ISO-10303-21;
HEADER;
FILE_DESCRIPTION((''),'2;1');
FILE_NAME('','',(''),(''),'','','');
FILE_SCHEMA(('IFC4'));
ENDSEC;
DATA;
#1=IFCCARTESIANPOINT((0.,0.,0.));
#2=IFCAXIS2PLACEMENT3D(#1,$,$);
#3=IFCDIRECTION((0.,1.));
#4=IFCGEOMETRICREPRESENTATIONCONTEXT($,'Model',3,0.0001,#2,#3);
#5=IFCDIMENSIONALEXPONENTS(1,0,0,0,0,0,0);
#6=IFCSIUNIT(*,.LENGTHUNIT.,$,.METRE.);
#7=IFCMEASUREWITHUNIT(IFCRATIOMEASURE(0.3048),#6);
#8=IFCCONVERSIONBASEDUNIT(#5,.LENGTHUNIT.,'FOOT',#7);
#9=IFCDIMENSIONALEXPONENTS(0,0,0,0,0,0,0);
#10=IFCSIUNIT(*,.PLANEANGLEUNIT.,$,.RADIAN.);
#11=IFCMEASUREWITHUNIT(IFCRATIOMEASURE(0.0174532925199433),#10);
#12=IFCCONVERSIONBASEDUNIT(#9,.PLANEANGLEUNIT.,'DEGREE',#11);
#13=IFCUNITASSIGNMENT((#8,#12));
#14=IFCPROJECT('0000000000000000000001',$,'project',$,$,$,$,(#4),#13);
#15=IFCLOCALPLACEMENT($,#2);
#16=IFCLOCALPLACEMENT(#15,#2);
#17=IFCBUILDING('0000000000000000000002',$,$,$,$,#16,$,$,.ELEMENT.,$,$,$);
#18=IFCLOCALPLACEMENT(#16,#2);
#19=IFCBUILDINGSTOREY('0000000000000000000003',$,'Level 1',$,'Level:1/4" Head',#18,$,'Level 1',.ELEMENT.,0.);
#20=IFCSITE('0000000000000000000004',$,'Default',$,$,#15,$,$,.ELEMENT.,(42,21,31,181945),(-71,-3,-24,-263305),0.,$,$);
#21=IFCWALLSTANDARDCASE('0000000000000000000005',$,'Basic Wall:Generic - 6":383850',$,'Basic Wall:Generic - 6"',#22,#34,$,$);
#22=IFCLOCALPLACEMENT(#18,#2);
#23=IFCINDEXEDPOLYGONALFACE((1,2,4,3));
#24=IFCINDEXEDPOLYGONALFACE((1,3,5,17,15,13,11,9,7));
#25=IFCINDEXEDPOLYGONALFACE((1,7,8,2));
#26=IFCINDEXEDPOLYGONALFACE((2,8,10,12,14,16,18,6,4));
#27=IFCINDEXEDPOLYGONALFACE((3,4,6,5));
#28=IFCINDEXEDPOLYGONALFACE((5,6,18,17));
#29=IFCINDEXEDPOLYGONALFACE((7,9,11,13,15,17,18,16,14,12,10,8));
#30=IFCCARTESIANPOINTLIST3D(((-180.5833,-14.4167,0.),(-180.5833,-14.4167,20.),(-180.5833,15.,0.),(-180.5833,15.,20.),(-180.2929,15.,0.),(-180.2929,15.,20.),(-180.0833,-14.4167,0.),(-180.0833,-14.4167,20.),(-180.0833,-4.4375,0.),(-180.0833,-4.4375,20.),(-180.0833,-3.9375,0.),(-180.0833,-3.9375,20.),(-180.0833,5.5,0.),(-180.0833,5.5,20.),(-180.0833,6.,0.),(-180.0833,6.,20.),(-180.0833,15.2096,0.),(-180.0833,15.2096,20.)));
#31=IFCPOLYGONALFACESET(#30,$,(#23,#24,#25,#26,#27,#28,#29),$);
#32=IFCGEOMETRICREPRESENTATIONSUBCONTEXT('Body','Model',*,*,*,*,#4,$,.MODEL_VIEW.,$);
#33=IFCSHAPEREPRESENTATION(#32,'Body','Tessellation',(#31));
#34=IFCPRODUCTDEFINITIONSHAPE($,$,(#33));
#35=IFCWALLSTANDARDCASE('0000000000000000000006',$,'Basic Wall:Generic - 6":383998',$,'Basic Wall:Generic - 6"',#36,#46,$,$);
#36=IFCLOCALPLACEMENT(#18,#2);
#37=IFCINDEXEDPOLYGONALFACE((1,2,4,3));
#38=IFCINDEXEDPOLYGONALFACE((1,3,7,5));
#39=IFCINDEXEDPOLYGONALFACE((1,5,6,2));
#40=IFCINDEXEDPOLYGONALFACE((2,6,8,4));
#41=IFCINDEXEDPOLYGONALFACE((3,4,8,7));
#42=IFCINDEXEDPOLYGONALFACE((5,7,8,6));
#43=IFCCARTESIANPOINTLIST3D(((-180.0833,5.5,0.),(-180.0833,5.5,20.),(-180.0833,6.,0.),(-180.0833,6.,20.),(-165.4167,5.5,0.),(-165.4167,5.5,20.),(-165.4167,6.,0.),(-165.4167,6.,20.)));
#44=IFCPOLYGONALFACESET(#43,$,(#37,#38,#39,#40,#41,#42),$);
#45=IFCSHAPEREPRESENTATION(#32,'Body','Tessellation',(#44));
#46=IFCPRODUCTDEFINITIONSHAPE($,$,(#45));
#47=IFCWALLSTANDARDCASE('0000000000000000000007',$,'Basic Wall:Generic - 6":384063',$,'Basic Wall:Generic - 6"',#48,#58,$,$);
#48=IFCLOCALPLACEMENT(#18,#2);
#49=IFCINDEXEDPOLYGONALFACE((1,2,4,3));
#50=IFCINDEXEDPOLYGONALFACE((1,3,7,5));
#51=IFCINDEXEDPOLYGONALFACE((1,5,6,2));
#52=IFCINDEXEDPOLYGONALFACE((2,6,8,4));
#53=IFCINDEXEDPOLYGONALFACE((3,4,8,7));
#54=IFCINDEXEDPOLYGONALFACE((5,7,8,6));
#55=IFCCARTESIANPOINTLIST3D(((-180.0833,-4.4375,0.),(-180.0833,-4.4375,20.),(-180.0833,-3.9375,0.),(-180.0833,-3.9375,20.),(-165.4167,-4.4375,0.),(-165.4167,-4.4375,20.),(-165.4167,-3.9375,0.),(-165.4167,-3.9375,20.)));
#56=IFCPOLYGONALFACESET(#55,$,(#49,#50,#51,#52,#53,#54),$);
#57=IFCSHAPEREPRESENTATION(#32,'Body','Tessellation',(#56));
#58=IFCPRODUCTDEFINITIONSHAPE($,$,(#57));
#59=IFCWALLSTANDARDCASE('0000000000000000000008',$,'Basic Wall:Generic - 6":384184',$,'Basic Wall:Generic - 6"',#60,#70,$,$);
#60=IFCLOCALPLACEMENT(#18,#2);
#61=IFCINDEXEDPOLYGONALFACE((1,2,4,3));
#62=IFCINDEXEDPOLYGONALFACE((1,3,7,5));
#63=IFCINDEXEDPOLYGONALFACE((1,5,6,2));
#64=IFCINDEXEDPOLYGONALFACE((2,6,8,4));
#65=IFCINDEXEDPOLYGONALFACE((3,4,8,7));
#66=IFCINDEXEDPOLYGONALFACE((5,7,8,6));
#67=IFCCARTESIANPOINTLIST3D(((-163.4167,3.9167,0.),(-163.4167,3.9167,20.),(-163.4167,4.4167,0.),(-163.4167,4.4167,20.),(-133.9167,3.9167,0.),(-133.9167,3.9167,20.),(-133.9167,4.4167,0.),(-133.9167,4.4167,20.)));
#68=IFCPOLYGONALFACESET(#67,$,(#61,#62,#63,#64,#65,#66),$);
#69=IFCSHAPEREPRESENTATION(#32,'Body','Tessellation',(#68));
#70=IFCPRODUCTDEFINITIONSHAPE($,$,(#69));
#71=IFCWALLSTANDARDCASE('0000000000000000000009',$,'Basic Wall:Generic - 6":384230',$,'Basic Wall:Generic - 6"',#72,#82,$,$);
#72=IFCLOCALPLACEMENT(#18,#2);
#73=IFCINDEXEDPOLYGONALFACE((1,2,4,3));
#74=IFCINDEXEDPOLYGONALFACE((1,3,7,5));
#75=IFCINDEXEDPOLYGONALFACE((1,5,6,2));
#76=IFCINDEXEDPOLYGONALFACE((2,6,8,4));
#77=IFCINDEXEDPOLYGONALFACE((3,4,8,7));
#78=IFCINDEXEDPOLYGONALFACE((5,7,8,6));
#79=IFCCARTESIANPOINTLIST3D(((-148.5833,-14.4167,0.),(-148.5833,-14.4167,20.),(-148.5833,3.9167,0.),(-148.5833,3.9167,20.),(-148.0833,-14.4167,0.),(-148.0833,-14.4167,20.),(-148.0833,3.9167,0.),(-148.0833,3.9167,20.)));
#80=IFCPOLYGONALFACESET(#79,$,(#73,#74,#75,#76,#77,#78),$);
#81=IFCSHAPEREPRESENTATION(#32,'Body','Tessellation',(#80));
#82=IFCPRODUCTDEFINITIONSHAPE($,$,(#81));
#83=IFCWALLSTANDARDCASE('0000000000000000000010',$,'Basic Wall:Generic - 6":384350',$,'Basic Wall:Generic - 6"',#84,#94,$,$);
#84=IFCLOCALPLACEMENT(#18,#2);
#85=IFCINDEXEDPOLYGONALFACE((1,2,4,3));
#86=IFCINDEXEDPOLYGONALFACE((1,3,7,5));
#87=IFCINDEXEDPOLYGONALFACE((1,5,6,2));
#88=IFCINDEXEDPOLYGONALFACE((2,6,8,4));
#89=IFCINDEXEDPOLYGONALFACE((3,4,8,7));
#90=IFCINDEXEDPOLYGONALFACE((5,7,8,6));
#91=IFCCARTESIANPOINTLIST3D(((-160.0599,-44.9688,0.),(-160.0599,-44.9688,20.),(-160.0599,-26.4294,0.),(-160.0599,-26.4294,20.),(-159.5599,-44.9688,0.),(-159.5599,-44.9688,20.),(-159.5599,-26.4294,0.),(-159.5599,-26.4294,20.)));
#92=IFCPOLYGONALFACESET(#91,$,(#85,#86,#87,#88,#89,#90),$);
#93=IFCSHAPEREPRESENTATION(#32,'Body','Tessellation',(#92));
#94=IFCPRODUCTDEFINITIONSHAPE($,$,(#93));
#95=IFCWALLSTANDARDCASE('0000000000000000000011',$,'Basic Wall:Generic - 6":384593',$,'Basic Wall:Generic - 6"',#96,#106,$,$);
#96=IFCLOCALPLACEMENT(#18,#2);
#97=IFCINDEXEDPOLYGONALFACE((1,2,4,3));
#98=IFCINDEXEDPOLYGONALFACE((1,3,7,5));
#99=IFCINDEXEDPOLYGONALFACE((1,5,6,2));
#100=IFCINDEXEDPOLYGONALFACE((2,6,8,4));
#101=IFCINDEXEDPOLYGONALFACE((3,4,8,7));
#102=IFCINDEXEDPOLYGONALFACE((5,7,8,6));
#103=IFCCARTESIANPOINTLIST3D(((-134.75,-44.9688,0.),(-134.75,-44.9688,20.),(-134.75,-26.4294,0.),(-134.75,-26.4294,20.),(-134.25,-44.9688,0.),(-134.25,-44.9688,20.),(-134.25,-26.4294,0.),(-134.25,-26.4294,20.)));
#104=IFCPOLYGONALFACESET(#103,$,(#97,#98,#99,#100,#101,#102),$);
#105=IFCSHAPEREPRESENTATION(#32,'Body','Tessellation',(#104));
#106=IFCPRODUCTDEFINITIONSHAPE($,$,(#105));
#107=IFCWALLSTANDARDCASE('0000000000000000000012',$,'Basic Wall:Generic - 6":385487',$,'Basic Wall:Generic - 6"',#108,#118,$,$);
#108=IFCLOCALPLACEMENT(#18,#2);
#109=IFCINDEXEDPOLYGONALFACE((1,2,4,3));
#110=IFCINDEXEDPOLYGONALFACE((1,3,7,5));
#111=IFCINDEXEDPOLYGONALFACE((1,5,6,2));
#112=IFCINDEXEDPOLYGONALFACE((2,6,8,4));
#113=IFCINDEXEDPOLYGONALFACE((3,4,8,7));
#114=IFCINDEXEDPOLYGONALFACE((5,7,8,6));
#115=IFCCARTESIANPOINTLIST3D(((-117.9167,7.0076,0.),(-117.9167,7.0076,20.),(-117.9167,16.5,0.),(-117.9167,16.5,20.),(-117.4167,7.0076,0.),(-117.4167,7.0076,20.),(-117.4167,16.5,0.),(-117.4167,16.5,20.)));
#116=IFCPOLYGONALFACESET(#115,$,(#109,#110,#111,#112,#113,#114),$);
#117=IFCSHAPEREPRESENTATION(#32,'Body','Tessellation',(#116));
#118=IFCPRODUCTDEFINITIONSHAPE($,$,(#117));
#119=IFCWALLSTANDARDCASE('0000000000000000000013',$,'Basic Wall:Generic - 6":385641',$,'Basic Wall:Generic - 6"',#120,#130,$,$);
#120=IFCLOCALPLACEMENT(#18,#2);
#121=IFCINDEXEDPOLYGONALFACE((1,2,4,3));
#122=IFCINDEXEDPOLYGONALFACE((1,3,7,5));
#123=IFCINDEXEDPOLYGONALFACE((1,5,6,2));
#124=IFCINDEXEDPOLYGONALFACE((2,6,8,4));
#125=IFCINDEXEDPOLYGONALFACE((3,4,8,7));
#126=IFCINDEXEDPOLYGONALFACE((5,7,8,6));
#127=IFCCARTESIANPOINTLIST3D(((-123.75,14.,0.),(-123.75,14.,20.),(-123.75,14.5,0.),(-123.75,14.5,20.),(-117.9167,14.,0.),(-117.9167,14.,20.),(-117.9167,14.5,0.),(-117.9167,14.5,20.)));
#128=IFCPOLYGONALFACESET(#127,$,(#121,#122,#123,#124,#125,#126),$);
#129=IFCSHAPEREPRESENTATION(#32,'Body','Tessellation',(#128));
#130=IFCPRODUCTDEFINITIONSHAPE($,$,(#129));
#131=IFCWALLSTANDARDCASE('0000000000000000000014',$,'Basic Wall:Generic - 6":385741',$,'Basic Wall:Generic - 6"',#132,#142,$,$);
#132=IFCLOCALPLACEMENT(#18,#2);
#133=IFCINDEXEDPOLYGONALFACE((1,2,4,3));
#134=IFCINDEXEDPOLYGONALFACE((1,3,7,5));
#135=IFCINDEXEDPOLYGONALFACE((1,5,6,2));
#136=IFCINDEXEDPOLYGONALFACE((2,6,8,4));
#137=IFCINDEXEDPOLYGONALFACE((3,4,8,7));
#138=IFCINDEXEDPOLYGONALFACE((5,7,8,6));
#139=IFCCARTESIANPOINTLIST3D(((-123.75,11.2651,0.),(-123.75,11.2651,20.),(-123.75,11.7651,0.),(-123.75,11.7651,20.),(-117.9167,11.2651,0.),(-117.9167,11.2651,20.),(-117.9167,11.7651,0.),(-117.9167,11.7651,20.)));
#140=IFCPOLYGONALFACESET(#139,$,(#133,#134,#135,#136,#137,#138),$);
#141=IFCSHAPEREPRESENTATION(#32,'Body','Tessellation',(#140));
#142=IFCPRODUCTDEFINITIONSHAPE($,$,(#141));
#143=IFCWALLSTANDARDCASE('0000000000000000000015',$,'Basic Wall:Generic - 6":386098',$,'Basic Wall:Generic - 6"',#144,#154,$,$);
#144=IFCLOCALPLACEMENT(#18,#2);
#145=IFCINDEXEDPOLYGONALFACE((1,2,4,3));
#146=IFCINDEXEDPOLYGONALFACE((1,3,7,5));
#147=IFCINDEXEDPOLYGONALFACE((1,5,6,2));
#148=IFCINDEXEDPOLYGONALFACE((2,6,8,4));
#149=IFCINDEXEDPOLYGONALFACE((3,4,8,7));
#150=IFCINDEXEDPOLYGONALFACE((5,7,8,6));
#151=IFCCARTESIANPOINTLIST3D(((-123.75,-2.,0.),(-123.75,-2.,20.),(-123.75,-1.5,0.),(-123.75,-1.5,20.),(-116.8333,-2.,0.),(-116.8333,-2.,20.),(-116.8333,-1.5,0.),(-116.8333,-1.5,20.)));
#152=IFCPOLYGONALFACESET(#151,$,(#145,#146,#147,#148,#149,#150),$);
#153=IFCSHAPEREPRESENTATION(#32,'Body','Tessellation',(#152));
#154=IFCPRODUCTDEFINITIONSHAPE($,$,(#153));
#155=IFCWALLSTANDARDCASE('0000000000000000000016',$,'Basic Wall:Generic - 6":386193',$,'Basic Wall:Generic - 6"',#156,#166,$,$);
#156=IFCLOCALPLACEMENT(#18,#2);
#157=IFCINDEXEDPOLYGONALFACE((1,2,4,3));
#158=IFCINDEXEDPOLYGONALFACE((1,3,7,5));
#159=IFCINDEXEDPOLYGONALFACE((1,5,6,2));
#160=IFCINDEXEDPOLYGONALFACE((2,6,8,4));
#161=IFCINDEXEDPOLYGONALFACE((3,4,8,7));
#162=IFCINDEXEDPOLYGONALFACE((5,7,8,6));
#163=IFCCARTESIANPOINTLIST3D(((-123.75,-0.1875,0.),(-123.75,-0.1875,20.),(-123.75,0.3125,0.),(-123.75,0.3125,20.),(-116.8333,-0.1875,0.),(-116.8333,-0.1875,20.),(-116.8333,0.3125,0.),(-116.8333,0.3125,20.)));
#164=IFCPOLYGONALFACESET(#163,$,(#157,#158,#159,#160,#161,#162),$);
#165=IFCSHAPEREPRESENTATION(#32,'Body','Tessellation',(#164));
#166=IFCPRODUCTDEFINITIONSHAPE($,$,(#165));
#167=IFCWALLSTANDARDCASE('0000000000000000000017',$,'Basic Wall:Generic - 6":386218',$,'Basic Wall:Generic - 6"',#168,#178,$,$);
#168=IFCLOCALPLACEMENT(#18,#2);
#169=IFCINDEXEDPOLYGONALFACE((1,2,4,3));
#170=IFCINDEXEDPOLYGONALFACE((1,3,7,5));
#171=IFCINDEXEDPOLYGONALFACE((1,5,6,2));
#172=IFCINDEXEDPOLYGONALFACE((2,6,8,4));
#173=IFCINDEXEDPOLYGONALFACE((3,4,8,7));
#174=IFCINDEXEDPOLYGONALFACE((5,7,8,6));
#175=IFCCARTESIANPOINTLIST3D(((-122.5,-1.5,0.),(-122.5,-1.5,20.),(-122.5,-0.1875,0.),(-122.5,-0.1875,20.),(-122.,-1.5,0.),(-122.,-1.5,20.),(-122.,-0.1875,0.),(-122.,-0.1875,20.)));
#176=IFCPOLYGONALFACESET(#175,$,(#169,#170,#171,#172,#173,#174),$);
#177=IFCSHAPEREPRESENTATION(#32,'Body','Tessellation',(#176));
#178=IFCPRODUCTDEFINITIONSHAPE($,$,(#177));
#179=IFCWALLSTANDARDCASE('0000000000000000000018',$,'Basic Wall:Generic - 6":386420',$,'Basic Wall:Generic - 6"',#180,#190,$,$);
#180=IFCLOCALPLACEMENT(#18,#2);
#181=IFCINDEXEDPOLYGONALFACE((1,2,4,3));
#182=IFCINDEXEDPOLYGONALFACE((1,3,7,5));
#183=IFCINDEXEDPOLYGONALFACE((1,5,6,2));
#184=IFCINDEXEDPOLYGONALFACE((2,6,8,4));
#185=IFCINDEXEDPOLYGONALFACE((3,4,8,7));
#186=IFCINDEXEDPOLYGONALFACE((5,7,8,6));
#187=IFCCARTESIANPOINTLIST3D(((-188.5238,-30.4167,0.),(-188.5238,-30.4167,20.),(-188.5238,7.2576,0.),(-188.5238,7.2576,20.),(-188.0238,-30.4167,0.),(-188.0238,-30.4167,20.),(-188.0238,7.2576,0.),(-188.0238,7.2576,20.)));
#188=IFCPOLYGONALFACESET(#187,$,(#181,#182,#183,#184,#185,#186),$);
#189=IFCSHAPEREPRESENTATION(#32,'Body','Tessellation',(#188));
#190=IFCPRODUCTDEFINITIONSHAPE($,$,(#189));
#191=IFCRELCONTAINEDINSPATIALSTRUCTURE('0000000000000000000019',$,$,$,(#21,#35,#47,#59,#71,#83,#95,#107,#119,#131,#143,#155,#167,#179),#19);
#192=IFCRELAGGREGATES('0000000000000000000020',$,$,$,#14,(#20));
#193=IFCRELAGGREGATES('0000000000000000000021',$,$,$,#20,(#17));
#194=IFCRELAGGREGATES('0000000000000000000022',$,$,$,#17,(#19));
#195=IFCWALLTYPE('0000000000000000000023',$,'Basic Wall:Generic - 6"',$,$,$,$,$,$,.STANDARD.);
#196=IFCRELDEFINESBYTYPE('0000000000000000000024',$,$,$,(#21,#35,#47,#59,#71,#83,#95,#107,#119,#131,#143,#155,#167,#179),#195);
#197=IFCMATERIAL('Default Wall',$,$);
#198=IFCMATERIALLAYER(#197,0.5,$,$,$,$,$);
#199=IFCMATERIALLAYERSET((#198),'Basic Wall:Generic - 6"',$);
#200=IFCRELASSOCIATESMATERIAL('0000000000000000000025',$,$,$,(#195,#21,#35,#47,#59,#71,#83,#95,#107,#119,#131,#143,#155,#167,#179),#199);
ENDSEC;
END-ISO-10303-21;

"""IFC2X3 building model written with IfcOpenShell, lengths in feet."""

from ifc_helpers import new_model, entity, si_unit, converted_unit, direction, frame, frame_2d, origin, place, context, subcontext, project, spatial, polyline, rectangle, outline, extrude, material, layer, layer_set, layer_usage, type_object, element, save


model = new_model("IFC2X3")

# Units and contexts
model_context = context("Model", 3, precision=0.0001, world=origin(), true_north=direction((0.0, 1.0)))
body_context = subcontext(model_context, "Body", "Model", "MODEL_VIEW")
ifc_project = project(units=[converted_unit("LENGTHUNIT", "FOOT", entity("IfcRatioMeasure", 0.3048), si_unit("LENGTHUNIT", "METRE"), dimensions=[1, 0, 0, 0, 0, 0, 0]), converted_unit("PLANEANGLEUNIT", "DEGREE", entity("IfcRatioMeasure", 0.0174532925199433), si_unit("PLANEANGLEUNIT", "RADIAN"), dimensions=[0, 0, 0, 0, 0, 0, 0])], contexts=[model_context])

# Site, building, storey
site_placement = place(None, origin())
site = spatial("IfcSite", under=ifc_project, at=site_placement, Name="Default", CompositionType="ELEMENT", RefLatitude=(42, 21, 31, 181945), RefLongitude=(-71, -3, -24, -263305), RefElevation=0.0)
building_placement = place(site_placement, origin())
building = spatial("IfcBuilding", under=site, at=building_placement, CompositionType="ELEMENT")
storey_placement = place(building_placement, origin())
storey = spatial("IfcBuildingStorey", under=building, at=storey_placement, Name="Level 1", ObjectType="Level:1/4\" Head", LongName="Level 1", CompositionType="ELEMENT", Elevation=0.0)

# Walls
ifc_material = material(Name="Default Wall")
ifc_layer_1 = layer(ifc_material, 0.5)
ifc_layer_set_1 = layer_set([ifc_layer_1], Name="Basic Wall:Generic - 6\"")
wall_type_1 = type_object("IfcWallType", Name="Basic Wall:Generic - 6\"", PredefinedType="STANDARD", material=ifc_layer_set_1)
ifc_layer_usage_1 = layer_usage(ifc_layer_set_1, "AXIS2", "NEGATIVE", 0.25)
wall_1_placement = place(storey_placement, frame((-180.3333, -14.4167, 0.0), z_axis=(0.0, 0.0, 1.0), x_axis=(0.0, 1.0, 0.0)))
element("IfcWallStandardCase", 1, at=wall_1_placement, inside=storey, type_object=wall_type_1, material=ifc_layer_usage_1, Name="Basic Wall:Generic - 6\":383850", ObjectType="Basic Wall:Generic - 6\"", context=body_context, shape_type="SweptSolid", body=[
    extrude(outline(polyline([(29.6263, -0.25), (29.4167, -0.0404), (29.4167, 0.25), (0.0, 0.25), (0.0, -0.25), (9.9792, -0.25), (10.4792, -0.25), (19.9167, -0.25), (20.4167, -0.25), (29.6263, -0.25)])), origin(), (0.0, 0.0, 1.0), 20.0),
])
ifc_layer_usage_2 = layer_usage(ifc_layer_set_1, "AXIS2", "NEGATIVE", 0.25)
wall_2_placement = place(storey_placement, frame((-180.0833, 5.75, 0.0)))
element("IfcWallStandardCase", 2, at=wall_2_placement, inside=storey, type_object=wall_type_1, material=ifc_layer_usage_2, Name="Basic Wall:Generic - 6\":383998", ObjectType="Basic Wall:Generic - 6\"", context=body_context, shape_type="SweptSolid", body=[
    extrude(rectangle(XDim=14.6667, YDim=0.5, at=frame_2d((7.3333, 0.0), x_axis=(-1.0, 0.0))), origin(), (0.0, 0.0, 1.0), 20.0),
])
ifc_layer_usage_3 = layer_usage(ifc_layer_set_1, "AXIS2", "NEGATIVE", 0.25)
wall_3_placement = place(storey_placement, frame((-180.0833, -4.1875, 0.0)))
element("IfcWallStandardCase", 3, at=wall_3_placement, inside=storey, type_object=wall_type_1, material=ifc_layer_usage_3, Name="Basic Wall:Generic - 6\":384063", ObjectType="Basic Wall:Generic - 6\"", context=body_context, shape_type="SweptSolid", body=[
    extrude(rectangle(XDim=14.6667, YDim=0.5, at=frame_2d((7.3333, 0.0), x_axis=(-1.0, 0.0))), origin(), (0.0, 0.0, 1.0), 20.0),
])
ifc_layer_usage_4 = layer_usage(ifc_layer_set_1, "AXIS2", "NEGATIVE", 0.25)
wall_4_placement = place(storey_placement, frame((-133.9167, 4.1667, 0.0), z_axis=(0.0, 0.0, 1.0), x_axis=(-1.0, 0.0, 0.0)))
element("IfcWallStandardCase", 4, at=wall_4_placement, inside=storey, type_object=wall_type_1, material=ifc_layer_usage_4, Name="Basic Wall:Generic - 6\":384184", ObjectType="Basic Wall:Generic - 6\"", context=body_context, shape_type="SweptSolid", body=[
    extrude(rectangle(XDim=29.5, YDim=0.5, at=frame_2d((14.75, 0.0), x_axis=(-1.0, 0.0))), origin(), (0.0, 0.0, 1.0), 20.0),
])
ifc_layer_usage_5 = layer_usage(ifc_layer_set_1, "AXIS2", "NEGATIVE", 0.25)
wall_5_placement = place(storey_placement, frame((-148.3333, -14.4167, 0.0), z_axis=(0.0, 0.0, 1.0), x_axis=(0.0, 1.0, 0.0)))
element("IfcWallStandardCase", 5, at=wall_5_placement, inside=storey, type_object=wall_type_1, material=ifc_layer_usage_5, Name="Basic Wall:Generic - 6\":384230", ObjectType="Basic Wall:Generic - 6\"", context=body_context, shape_type="SweptSolid", body=[
    extrude(rectangle(XDim=18.3333, YDim=0.5, at=frame_2d((9.1667, 0.0), x_axis=(-1.0, 0.0))), origin(), (0.0, 0.0, 1.0), 20.0),
])
ifc_layer_usage_6 = layer_usage(ifc_layer_set_1, "AXIS2", "NEGATIVE", 0.25)
wall_6_placement = place(storey_placement, frame((-159.8099, -26.4294, 0.0), z_axis=(0.0, 0.0, 1.0), x_axis=(0.0, -1.0, 0.0)))
element("IfcWallStandardCase", 6, at=wall_6_placement, inside=storey, type_object=wall_type_1, material=ifc_layer_usage_6, Name="Basic Wall:Generic - 6\":384350", ObjectType="Basic Wall:Generic - 6\"", context=body_context, shape_type="SweptSolid", body=[
    extrude(rectangle(XDim=18.5394, YDim=0.5, at=frame_2d((9.2697, 0.0), x_axis=(-1.0, 0.0))), origin(), (0.0, 0.0, 1.0), 20.0),
])
ifc_layer_usage_7 = layer_usage(ifc_layer_set_1, "AXIS2", "NEGATIVE", 0.25)
wall_7_placement = place(storey_placement, frame((-134.5, -26.4294, 0.0), z_axis=(0.0, 0.0, 1.0), x_axis=(0.0, -1.0, 0.0)))
element("IfcWallStandardCase", 7, at=wall_7_placement, inside=storey, type_object=wall_type_1, material=ifc_layer_usage_7, Name="Basic Wall:Generic - 6\":384593", ObjectType="Basic Wall:Generic - 6\"", context=body_context, shape_type="SweptSolid", body=[
    extrude(rectangle(XDim=18.5394, YDim=0.5, at=frame_2d((9.2697, 0.0), x_axis=(-1.0, 0.0))), origin(), (0.0, 0.0, 1.0), 20.0),
])
ifc_layer_usage_8 = layer_usage(ifc_layer_set_1, "AXIS2", "NEGATIVE", 0.25)
wall_8_placement = place(storey_placement, frame((-117.6667, 7.0076, 0.0), z_axis=(0.0, 0.0, 1.0), x_axis=(0.0, 1.0, 0.0)))
element("IfcWallStandardCase", 8, at=wall_8_placement, inside=storey, type_object=wall_type_1, material=ifc_layer_usage_8, Name="Basic Wall:Generic - 6\":385487", ObjectType="Basic Wall:Generic - 6\"", context=body_context, shape_type="SweptSolid", body=[
    extrude(rectangle(XDim=9.4924, YDim=0.5, at=frame_2d((4.7462, 0.0), x_axis=(-1.0, 0.0))), origin(), (0.0, 0.0, 1.0), 20.0),
])
ifc_layer_usage_9 = layer_usage(ifc_layer_set_1, "AXIS2", "NEGATIVE", 0.25)
wall_9_placement = place(storey_placement, frame((-117.9167, 14.25, 0.0), z_axis=(0.0, 0.0, 1.0), x_axis=(-1.0, 0.0, 0.0)))
element("IfcWallStandardCase", 9, at=wall_9_placement, inside=storey, type_object=wall_type_1, material=ifc_layer_usage_9, Name="Basic Wall:Generic - 6\":385641", ObjectType="Basic Wall:Generic - 6\"", context=body_context, shape_type="SweptSolid", body=[
    extrude(rectangle(XDim=5.8333, YDim=0.5, at=frame_2d((2.9167, 0.0), x_axis=(-1.0, 0.0))), origin(), (0.0, 0.0, 1.0), 20.0),
])
ifc_layer_usage_10 = layer_usage(ifc_layer_set_1, "AXIS2", "NEGATIVE", 0.25)
wall_10_placement = place(storey_placement, frame((-123.75, 11.5151, 0.0)))
element("IfcWallStandardCase", 10, at=wall_10_placement, inside=storey, type_object=wall_type_1, material=ifc_layer_usage_10, Name="Basic Wall:Generic - 6\":385741", ObjectType="Basic Wall:Generic - 6\"", context=body_context, shape_type="SweptSolid", body=[
    extrude(rectangle(XDim=5.8333, YDim=0.5, at=frame_2d((2.9167, 0.0), x_axis=(-1.0, 0.0))), origin(), (0.0, 0.0, 1.0), 20.0),
])
ifc_layer_usage_11 = layer_usage(ifc_layer_set_1, "AXIS2", "NEGATIVE", 0.25)
wall_11_placement = place(storey_placement, frame((-123.75, -1.75, 0.0)))
element("IfcWallStandardCase", 11, at=wall_11_placement, inside=storey, type_object=wall_type_1, material=ifc_layer_usage_11, Name="Basic Wall:Generic - 6\":386098", ObjectType="Basic Wall:Generic - 6\"", context=body_context, shape_type="SweptSolid", body=[
    extrude(rectangle(XDim=6.9167, YDim=0.5, at=frame_2d((3.4583, 0.0), x_axis=(-1.0, 0.0))), origin(), (0.0, 0.0, 1.0), 20.0),
])
ifc_layer_usage_12 = layer_usage(ifc_layer_set_1, "AXIS2", "NEGATIVE", 0.25)
wall_12_placement = place(storey_placement, frame((-123.75, 0.0625, 0.0)))
element("IfcWallStandardCase", 12, at=wall_12_placement, inside=storey, type_object=wall_type_1, material=ifc_layer_usage_12, Name="Basic Wall:Generic - 6\":386193", ObjectType="Basic Wall:Generic - 6\"", context=body_context, shape_type="SweptSolid", body=[
    extrude(rectangle(XDim=6.9167, YDim=0.5, at=frame_2d((3.4583, 0.0), x_axis=(-1.0, 0.0))), origin(), (0.0, 0.0, 1.0), 20.0),
])
ifc_layer_usage_13 = layer_usage(ifc_layer_set_1, "AXIS2", "NEGATIVE", 0.25)
wall_13_placement = place(storey_placement, frame((-122.25, -1.5, 0.0), z_axis=(0.0, 0.0, 1.0), x_axis=(0.0, 1.0, 0.0)))
element("IfcWallStandardCase", 13, at=wall_13_placement, inside=storey, type_object=wall_type_1, material=ifc_layer_usage_13, Name="Basic Wall:Generic - 6\":386218", ObjectType="Basic Wall:Generic - 6\"", context=body_context, shape_type="SweptSolid", body=[
    extrude(rectangle(XDim=1.3125, YDim=0.5, at=frame_2d((0.6563, 0.0), x_axis=(-1.0, 0.0))), origin(), (0.0, 0.0, 1.0), 20.0),
])
ifc_layer_usage_14 = layer_usage(ifc_layer_set_1, "AXIS2", "NEGATIVE", 0.25)
wall_14_placement = place(storey_placement, frame((-188.2738, -30.4167, 0.0), z_axis=(0.0, 0.0, 1.0), x_axis=(0.0, 1.0, 0.0)))
element("IfcWallStandardCase", 14, at=wall_14_placement, inside=storey, type_object=wall_type_1, material=ifc_layer_usage_14, Name="Basic Wall:Generic - 6\":386420", ObjectType="Basic Wall:Generic - 6\"", context=body_context, shape_type="SweptSolid", body=[
    extrude(rectangle(XDim=37.6743, YDim=0.5, at=frame_2d((18.8372, 0.0), x_axis=(-1.0, 0.0))), origin(), (0.0, 0.0, 1.0), 20.0),
])

save(model, "model.ifc")
